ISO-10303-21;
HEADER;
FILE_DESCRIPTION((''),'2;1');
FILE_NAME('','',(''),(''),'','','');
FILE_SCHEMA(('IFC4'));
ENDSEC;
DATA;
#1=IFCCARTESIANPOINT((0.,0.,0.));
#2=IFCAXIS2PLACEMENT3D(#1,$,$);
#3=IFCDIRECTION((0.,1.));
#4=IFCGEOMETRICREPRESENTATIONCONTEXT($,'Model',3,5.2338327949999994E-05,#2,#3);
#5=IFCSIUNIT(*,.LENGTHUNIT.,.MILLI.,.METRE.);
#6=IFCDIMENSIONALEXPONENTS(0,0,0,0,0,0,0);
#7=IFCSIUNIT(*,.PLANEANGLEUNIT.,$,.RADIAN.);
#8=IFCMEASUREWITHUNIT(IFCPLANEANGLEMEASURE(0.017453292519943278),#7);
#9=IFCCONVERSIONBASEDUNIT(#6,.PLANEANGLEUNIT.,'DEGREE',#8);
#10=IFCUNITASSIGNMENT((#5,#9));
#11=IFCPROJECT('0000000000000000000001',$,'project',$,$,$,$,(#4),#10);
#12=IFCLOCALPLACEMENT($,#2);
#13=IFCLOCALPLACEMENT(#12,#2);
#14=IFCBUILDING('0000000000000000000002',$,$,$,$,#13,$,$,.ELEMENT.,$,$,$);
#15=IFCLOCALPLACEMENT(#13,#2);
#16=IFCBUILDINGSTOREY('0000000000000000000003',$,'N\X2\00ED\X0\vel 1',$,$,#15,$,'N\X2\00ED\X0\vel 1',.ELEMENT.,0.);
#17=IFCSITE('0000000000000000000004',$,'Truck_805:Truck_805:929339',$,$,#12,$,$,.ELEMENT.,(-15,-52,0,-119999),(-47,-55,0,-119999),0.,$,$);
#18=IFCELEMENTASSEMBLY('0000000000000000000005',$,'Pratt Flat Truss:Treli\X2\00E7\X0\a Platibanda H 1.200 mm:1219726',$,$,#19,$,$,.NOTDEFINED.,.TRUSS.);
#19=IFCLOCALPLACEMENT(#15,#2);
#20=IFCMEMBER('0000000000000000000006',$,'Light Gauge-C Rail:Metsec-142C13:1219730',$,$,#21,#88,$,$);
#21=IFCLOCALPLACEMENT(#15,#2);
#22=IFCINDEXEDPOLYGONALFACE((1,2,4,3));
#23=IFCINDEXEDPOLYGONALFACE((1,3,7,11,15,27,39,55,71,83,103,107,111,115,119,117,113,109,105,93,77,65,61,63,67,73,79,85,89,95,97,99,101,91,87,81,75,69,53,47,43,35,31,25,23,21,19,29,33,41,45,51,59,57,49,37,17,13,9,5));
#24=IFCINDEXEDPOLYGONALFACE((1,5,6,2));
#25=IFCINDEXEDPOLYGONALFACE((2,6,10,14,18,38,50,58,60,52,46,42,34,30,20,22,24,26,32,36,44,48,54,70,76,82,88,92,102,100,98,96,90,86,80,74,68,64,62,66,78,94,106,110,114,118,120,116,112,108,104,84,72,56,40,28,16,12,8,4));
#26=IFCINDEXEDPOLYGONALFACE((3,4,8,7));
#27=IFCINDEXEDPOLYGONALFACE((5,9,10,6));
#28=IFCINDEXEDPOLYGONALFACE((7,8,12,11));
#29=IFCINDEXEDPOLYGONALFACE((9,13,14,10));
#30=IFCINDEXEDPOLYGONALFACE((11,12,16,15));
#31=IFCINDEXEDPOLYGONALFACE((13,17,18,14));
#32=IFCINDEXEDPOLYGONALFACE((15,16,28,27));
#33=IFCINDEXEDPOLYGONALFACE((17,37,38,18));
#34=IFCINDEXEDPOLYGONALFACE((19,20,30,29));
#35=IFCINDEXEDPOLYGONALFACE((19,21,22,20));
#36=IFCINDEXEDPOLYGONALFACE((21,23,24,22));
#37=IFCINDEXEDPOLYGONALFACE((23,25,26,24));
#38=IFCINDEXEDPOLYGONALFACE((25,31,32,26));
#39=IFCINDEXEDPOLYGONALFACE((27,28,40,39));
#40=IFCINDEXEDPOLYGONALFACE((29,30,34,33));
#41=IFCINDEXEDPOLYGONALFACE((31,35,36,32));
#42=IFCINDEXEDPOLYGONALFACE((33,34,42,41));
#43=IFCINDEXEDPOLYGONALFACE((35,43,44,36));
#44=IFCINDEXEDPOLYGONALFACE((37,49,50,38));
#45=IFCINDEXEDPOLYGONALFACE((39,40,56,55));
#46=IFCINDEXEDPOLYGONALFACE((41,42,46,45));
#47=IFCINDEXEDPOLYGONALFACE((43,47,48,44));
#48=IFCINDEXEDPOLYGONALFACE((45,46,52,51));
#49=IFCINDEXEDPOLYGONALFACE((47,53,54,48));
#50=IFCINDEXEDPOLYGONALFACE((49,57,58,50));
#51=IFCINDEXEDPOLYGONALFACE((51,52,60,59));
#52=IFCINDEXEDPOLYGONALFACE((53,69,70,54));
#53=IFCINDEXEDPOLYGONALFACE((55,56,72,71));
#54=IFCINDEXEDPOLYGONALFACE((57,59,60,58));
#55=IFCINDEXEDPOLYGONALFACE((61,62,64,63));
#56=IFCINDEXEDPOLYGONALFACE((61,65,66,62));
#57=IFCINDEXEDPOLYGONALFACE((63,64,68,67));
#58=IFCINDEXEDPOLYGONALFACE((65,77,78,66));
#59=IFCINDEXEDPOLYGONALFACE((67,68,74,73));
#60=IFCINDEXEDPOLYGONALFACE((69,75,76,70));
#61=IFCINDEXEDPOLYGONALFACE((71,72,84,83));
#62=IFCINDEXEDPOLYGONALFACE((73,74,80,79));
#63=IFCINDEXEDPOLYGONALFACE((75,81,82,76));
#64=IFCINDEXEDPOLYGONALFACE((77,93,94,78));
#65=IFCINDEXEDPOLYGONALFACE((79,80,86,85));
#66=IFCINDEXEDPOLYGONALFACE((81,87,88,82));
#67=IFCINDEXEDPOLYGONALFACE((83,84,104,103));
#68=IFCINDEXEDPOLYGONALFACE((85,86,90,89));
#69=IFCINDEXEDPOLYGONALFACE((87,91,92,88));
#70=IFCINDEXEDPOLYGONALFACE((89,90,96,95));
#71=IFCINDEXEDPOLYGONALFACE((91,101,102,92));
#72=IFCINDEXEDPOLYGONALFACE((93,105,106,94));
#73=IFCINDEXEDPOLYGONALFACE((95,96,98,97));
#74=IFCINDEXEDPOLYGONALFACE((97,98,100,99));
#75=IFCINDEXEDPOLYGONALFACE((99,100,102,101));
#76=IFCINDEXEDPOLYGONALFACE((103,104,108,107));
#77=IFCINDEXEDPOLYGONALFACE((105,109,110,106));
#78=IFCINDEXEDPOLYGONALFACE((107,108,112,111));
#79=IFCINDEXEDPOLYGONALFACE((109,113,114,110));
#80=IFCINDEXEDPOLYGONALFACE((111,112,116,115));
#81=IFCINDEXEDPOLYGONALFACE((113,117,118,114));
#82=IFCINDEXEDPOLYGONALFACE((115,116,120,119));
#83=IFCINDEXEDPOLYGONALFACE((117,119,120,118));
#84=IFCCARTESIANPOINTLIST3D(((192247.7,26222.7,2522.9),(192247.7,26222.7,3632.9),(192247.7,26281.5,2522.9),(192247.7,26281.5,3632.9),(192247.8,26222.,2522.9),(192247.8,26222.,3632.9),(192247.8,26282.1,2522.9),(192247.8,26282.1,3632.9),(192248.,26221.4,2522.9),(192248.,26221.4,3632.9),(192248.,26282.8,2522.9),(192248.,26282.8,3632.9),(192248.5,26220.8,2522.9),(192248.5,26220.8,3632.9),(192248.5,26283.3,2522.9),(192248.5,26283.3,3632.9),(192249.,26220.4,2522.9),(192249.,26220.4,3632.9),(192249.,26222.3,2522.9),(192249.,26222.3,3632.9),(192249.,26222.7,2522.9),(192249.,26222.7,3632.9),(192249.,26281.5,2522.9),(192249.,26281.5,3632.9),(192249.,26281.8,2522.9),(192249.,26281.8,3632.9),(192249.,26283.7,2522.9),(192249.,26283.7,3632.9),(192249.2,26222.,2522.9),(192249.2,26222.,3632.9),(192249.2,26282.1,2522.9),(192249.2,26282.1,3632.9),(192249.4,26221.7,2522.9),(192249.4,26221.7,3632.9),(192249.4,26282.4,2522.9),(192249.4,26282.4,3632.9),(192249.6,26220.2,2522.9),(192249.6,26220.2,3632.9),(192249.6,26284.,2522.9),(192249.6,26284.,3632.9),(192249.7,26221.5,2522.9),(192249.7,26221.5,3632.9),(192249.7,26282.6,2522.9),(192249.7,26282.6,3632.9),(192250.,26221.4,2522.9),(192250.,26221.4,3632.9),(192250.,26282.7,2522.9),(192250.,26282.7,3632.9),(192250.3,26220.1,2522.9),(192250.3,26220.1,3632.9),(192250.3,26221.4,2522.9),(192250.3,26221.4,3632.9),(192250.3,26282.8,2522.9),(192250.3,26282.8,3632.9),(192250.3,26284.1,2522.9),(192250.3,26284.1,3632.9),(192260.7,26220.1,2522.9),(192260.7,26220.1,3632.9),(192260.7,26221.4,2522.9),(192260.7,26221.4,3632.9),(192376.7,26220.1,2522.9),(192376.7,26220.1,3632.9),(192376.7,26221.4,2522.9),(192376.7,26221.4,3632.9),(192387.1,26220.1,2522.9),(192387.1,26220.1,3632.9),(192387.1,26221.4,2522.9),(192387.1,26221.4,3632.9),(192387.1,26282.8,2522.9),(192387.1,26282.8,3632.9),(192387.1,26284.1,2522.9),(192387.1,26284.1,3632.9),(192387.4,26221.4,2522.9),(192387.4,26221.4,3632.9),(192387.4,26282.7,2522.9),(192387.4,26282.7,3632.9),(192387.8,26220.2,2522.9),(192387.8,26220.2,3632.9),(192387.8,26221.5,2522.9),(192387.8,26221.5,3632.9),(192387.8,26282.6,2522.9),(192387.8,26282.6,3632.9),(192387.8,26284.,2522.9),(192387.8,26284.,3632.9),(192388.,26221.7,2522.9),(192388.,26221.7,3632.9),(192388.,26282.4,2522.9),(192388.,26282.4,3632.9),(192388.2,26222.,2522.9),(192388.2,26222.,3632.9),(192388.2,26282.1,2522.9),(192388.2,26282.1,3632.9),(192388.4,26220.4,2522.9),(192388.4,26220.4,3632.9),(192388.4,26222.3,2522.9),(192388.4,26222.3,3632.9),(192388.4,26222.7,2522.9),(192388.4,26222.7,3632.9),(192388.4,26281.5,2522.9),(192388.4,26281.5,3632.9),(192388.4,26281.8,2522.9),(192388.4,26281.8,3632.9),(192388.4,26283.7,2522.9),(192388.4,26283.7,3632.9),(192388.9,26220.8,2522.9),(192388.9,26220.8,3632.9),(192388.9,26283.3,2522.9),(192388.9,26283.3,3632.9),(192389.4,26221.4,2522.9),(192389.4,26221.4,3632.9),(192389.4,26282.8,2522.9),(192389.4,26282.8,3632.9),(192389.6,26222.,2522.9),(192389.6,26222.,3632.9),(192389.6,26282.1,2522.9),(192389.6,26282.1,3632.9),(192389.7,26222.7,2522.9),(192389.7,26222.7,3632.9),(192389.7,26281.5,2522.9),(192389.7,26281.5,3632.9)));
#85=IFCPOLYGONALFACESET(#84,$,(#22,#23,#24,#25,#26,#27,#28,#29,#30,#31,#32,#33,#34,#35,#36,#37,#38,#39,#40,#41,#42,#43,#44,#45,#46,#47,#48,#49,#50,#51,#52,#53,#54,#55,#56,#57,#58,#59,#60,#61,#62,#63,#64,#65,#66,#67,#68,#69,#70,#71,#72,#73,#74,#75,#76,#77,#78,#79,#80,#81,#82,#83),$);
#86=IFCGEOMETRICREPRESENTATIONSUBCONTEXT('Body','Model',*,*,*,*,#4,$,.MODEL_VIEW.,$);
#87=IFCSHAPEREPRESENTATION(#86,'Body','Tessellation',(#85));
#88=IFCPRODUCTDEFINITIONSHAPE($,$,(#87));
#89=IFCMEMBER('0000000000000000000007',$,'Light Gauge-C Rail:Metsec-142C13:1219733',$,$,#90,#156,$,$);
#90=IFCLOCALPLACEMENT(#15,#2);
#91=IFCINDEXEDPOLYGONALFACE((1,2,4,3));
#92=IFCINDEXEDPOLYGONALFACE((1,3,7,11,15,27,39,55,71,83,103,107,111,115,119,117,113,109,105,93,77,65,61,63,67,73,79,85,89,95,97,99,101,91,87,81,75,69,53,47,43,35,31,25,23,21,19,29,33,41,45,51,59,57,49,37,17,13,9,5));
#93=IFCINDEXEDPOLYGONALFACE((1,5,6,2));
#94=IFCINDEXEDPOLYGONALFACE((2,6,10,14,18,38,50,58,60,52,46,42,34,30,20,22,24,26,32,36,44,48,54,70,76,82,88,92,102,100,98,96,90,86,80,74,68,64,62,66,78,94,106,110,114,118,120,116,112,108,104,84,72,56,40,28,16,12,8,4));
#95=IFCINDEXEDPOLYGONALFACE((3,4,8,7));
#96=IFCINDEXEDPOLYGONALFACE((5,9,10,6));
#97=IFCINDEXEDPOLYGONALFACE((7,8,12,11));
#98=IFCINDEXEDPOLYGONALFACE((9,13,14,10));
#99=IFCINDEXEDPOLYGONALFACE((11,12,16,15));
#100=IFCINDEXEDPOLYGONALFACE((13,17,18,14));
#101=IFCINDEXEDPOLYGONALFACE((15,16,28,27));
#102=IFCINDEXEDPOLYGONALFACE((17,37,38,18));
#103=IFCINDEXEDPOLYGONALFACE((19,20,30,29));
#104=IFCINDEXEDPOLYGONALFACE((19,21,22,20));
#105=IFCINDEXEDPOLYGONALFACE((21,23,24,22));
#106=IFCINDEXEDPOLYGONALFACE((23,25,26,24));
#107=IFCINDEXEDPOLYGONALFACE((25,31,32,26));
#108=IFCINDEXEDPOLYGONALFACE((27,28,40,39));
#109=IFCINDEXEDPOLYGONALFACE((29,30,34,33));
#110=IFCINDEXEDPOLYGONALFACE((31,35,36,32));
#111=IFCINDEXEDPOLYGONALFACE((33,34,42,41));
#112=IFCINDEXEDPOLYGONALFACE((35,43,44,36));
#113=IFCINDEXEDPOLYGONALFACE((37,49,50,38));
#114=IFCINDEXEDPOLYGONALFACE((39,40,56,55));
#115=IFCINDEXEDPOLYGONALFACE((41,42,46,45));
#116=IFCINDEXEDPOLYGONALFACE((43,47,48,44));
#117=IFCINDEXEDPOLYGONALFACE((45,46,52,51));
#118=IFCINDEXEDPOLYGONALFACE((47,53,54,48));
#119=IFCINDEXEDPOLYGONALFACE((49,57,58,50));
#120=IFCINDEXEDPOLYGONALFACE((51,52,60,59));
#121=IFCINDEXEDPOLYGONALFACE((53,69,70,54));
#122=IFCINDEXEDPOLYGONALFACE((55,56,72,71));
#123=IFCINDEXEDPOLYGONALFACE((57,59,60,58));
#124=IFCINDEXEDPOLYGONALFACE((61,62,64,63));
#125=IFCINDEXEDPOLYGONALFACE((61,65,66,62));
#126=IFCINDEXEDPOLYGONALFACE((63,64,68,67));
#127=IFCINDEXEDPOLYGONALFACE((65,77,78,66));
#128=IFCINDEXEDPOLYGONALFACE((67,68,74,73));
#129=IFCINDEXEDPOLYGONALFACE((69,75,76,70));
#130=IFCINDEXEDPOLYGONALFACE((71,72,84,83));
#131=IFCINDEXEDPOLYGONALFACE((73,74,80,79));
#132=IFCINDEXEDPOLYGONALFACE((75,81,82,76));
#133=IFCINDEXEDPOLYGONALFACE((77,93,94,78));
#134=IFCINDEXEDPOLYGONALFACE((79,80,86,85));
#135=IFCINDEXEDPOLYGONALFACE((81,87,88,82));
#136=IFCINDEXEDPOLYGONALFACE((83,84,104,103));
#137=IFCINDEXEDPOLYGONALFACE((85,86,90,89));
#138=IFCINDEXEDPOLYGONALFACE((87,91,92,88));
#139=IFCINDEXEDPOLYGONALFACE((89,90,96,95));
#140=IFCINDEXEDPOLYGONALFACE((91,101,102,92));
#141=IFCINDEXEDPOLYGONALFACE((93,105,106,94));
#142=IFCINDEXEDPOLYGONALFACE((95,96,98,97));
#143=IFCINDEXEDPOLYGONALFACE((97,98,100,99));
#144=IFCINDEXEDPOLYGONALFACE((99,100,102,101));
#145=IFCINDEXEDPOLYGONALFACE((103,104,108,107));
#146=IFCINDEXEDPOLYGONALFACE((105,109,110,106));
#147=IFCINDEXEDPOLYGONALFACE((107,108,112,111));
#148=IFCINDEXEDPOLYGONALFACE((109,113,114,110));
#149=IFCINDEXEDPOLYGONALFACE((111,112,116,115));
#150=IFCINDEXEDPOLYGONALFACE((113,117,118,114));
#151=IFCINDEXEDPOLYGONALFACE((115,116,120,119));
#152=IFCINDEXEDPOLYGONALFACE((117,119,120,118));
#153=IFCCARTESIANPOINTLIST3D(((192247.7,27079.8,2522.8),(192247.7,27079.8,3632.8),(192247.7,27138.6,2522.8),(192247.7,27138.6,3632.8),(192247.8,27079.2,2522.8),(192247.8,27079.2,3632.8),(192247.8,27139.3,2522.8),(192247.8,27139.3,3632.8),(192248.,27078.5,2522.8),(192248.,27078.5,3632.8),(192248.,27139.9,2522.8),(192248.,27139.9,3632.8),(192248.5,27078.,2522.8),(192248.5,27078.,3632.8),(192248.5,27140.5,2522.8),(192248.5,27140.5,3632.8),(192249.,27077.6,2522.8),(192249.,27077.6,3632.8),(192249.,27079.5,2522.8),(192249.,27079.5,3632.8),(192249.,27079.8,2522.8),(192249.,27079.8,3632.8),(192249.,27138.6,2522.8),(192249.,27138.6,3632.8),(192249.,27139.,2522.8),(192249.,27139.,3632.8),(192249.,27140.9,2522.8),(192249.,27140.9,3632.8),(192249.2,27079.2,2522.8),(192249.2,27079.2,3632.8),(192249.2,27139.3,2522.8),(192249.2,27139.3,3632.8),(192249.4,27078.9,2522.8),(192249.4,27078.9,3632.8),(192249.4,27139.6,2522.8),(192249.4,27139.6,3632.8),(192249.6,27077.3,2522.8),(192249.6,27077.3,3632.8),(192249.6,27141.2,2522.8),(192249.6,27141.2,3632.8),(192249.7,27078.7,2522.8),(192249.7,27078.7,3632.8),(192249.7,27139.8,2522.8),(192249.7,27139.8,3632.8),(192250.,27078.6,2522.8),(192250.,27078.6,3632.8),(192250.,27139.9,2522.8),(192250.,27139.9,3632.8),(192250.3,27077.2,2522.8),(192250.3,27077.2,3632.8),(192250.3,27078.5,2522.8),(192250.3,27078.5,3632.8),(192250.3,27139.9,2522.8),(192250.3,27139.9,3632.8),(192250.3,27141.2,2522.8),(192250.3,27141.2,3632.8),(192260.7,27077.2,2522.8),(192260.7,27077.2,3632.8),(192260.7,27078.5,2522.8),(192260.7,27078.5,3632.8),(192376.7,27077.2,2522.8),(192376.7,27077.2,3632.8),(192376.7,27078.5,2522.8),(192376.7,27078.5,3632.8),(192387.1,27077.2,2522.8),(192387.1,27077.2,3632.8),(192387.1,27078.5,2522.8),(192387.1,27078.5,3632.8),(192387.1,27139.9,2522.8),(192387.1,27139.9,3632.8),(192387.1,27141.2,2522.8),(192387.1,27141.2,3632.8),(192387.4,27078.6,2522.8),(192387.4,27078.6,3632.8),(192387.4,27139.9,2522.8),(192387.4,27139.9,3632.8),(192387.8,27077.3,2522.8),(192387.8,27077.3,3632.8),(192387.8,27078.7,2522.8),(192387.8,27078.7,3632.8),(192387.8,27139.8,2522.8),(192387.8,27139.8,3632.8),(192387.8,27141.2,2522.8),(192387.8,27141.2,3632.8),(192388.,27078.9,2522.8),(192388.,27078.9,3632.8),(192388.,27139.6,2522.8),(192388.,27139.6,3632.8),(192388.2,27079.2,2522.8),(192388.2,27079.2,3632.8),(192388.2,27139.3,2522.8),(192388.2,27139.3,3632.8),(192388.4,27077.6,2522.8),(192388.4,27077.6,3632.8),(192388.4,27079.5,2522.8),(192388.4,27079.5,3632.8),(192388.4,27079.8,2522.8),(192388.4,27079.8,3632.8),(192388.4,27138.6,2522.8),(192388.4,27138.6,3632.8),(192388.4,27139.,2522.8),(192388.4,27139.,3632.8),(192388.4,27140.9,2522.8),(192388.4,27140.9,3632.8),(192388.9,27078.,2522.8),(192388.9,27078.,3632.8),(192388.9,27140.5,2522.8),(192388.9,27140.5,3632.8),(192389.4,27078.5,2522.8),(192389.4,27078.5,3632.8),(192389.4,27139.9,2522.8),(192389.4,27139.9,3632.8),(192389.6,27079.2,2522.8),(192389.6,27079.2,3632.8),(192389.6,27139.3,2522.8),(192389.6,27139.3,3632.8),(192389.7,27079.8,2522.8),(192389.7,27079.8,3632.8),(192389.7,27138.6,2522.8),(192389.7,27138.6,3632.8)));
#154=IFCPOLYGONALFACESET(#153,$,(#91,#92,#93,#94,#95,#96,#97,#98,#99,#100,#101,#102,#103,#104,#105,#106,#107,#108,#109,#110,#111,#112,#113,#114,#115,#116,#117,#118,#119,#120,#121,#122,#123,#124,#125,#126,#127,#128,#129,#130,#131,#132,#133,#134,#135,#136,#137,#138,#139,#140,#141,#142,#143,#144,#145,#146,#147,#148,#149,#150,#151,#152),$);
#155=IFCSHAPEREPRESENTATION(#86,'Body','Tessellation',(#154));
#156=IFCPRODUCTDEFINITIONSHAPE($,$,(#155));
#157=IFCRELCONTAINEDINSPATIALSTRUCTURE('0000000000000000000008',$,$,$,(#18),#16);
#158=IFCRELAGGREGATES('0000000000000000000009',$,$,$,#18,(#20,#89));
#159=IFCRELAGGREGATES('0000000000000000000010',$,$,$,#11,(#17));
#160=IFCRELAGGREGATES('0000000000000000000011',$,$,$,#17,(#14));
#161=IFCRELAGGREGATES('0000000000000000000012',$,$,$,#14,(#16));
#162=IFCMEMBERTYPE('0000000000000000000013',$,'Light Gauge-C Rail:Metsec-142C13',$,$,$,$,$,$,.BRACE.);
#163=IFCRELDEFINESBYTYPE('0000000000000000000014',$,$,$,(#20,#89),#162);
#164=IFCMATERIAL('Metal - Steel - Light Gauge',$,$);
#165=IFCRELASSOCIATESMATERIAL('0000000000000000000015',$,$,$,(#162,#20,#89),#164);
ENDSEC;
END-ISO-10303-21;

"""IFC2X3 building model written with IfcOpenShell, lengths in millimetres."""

from ifc_helpers import new_model, entity, si_unit, converted_unit, direction, frame, frame_2d, origin, place, context, subcontext, project, spatial, polyline, circle_curve, parameter, trimmed, segment, composite_curve, outline, extrude, source, transform, mapped, material, type_object, type_shapes, element, aggregate, save


model = new_model("IFC2X3")

# Units and contexts
model_context = context("Model", 3, precision=5.2338327949999994e-05, world=origin(), true_north=direction((0.0, 1.0)))
body_context = subcontext(model_context, "Body", "Model", "MODEL_VIEW")
ifc_project = project(units=[si_unit("LENGTHUNIT", "METRE", prefix="MILLI"), converted_unit("PLANEANGLEUNIT", "DEGREE", entity("IfcPlaneAngleMeasure", 0.017453292519943278), si_unit("PLANEANGLEUNIT", "RADIAN"), dimensions=[0, 0, 0, 0, 0, 0, 0])], contexts=[model_context])

# Site, building, storey
site_placement = place(None, origin())
site = spatial("IfcSite", under=ifc_project, at=site_placement, Name="Truck_805:Truck_805:929339", CompositionType="ELEMENT", RefLatitude=(-15, -52, 0, -119999), RefLongitude=(-47, -55, 0, -119999), RefElevation=0.0)
building_placement = place(site_placement, origin())
building = spatial("IfcBuilding", under=site, at=building_placement, CompositionType="ELEMENT")
storey_placement = place(building_placement, origin())
storey = spatial("IfcBuildingStorey", under=building, at=storey_placement, Name="Nível 1", LongName="Nível 1", CompositionType="ELEMENT", Elevation=0.0)

# Element assembly, members
assembly_1_placement = place(storey_placement, origin())
assembly_1 = element("IfcElementAssembly", 1, at=assembly_1_placement, inside=storey, Name="Pratt Flat Truss:Treliça Platibanda H 1.200 mm:1219726", AssemblyPlace="NOTDEFINED", PredefinedType="TRUSS")
ifc_material_1 = material(Name="Metal - Steel - Light Gauge")
member_type_1 = type_object("IfcMemberType", Name="Light Gauge-C Rail:Metsec-142C13", PredefinedType="BRACE", material=ifc_material_1)
shared_shape_1 = source(origin(), body_context, "Body", "SweptSolid", [
    extrude(outline(composite_curve([segment(polyline([(-23.1, -71.0), (35.7, -71.0)]), True, "CONTINUOUS"), segment(trimmed(circle_curve(frame_2d((35.7, -68.4), x_axis=(0.0, -1.0)), 2.6), [parameter(0.0)], [parameter(90.0)], True, "PARAMETER"), True, "CONTINUOUS"), segment(polyline([(38.3, -68.4), (38.3, 68.4)]), True, "CONTINUOUS"), segment(trimmed(circle_curve(frame_2d((35.7, 68.4), x_axis=(1.0, 0.0)), 2.6), [parameter(0.0)], [parameter(90.0)], True, "PARAMETER"), True, "CONTINUOUS"), segment(polyline([(35.7, 71.0), (-23.1, 71.0)]), True, "CONTINUOUS"), segment(trimmed(circle_curve(frame_2d((-23.1, 68.4), x_axis=(0.0, 1.0)), 2.6), [parameter(0.0)], [parameter(90.0)], True, "PARAMETER"), True, "CONTINUOUS"), segment(polyline([(-25.7, 68.4), (-25.7, 58.0)]), True, "CONTINUOUS"), segment(polyline([(-25.7, 58.0), (-24.4, 58.0)]), True, "CONTINUOUS"), segment(polyline([(-24.4, 58.0), (-24.4, 68.4)]), True, "CONTINUOUS"), segment(trimmed(circle_curve(frame_2d((-23.1, 68.4), x_axis=(-1.0, 0.0)), 1.3), [parameter(270.0)], [parameter(0.0)], True, "PARAMETER"), False, "CONTINUOUS"), segment(polyline([(-23.1, 69.7), (35.7, 69.7)]), True, "CONTINUOUS"), segment(trimmed(circle_curve(frame_2d((35.7, 68.4), x_axis=(0.0, 1.0)), 1.3), [parameter(270.0)], [parameter(0.0)], True, "PARAMETER"), False, "CONTINUOUS"), segment(polyline([(37.0, 68.4), (37.0, -68.4)]), True, "CONTINUOUS"), segment(trimmed(circle_curve(frame_2d((35.7, -68.4), x_axis=(1.0, 0.0)), 1.3), [parameter(270.0)], [parameter(0.0)], True, "PARAMETER"), False, "CONTINUOUS"), segment(polyline([(35.7, -69.7), (-23.1, -69.7)]), True, "CONTINUOUS"), segment(trimmed(circle_curve(frame_2d((-23.1, -68.4), x_axis=(0.0, -1.0)), 1.3), [parameter(270.0)], [parameter(0.0)], True, "PARAMETER"), False, "CONTINUOUS"), segment(polyline([(-24.4, -68.4), (-24.4, -58.0)]), True, "CONTINUOUS"), segment(polyline([(-24.4, -58.0), (-25.7, -58.0)]), True, "CONTINUOUS"), segment(polyline([(-25.7, -58.0), (-25.7, -68.4)]), True, "CONTINUOUS"), segment(trimmed(circle_curve(frame_2d((-23.1, -68.4), x_axis=(-1.0, 0.0)), 2.6), [parameter(0.0)], [parameter(90.0)], True, "PARAMETER"), True, "CONTINUOUS")], self_intersect=False)), frame((-555.0, 0.0, 18.8), z_axis=(1.0, 0.0, 0.0), x_axis=(0.0, 0.0, -1.0)), (0.0, 0.0, 1.0), 1110.0),
])
type_shapes(member_type_1, [shared_shape_1])
member_1_placement = place(assembly_1_placement, frame((192318.7, 26264.6, 3077.9), z_axis=(0.0, -1.0, 0.0), x_axis=(0.0, 0.0, 1.0)))
member_1 = element("IfcMember", 2, at=member_1_placement, type_object=member_type_1, material=ifc_material_1, Name="Light Gauge-C Rail:Metsec-142C13:1219730", context=body_context, shape_type="MappedRepresentation", body=[
    mapped(shared_shape_1, transform((0.0, 0.0, 0.0), scale=1.0)),
])
member_2_placement = place(assembly_1_placement, frame((192318.7, 27121.7, 3077.8), z_axis=(0.0, -1.0, 0.0), x_axis=(0.0, 0.0, 1.0)))
member_2 = element("IfcMember", 3, at=member_2_placement, type_object=member_type_1, material=ifc_material_1, Name="Light Gauge-C Rail:Metsec-142C13:1219733", context=body_context, shape_type="MappedRepresentation", body=[
    mapped(shared_shape_1, transform((0.0, 0.0, 0.0), scale=1.0)),
])
aggregate(assembly_1, [member_1, member_2])

save(model, "model.ifc")
